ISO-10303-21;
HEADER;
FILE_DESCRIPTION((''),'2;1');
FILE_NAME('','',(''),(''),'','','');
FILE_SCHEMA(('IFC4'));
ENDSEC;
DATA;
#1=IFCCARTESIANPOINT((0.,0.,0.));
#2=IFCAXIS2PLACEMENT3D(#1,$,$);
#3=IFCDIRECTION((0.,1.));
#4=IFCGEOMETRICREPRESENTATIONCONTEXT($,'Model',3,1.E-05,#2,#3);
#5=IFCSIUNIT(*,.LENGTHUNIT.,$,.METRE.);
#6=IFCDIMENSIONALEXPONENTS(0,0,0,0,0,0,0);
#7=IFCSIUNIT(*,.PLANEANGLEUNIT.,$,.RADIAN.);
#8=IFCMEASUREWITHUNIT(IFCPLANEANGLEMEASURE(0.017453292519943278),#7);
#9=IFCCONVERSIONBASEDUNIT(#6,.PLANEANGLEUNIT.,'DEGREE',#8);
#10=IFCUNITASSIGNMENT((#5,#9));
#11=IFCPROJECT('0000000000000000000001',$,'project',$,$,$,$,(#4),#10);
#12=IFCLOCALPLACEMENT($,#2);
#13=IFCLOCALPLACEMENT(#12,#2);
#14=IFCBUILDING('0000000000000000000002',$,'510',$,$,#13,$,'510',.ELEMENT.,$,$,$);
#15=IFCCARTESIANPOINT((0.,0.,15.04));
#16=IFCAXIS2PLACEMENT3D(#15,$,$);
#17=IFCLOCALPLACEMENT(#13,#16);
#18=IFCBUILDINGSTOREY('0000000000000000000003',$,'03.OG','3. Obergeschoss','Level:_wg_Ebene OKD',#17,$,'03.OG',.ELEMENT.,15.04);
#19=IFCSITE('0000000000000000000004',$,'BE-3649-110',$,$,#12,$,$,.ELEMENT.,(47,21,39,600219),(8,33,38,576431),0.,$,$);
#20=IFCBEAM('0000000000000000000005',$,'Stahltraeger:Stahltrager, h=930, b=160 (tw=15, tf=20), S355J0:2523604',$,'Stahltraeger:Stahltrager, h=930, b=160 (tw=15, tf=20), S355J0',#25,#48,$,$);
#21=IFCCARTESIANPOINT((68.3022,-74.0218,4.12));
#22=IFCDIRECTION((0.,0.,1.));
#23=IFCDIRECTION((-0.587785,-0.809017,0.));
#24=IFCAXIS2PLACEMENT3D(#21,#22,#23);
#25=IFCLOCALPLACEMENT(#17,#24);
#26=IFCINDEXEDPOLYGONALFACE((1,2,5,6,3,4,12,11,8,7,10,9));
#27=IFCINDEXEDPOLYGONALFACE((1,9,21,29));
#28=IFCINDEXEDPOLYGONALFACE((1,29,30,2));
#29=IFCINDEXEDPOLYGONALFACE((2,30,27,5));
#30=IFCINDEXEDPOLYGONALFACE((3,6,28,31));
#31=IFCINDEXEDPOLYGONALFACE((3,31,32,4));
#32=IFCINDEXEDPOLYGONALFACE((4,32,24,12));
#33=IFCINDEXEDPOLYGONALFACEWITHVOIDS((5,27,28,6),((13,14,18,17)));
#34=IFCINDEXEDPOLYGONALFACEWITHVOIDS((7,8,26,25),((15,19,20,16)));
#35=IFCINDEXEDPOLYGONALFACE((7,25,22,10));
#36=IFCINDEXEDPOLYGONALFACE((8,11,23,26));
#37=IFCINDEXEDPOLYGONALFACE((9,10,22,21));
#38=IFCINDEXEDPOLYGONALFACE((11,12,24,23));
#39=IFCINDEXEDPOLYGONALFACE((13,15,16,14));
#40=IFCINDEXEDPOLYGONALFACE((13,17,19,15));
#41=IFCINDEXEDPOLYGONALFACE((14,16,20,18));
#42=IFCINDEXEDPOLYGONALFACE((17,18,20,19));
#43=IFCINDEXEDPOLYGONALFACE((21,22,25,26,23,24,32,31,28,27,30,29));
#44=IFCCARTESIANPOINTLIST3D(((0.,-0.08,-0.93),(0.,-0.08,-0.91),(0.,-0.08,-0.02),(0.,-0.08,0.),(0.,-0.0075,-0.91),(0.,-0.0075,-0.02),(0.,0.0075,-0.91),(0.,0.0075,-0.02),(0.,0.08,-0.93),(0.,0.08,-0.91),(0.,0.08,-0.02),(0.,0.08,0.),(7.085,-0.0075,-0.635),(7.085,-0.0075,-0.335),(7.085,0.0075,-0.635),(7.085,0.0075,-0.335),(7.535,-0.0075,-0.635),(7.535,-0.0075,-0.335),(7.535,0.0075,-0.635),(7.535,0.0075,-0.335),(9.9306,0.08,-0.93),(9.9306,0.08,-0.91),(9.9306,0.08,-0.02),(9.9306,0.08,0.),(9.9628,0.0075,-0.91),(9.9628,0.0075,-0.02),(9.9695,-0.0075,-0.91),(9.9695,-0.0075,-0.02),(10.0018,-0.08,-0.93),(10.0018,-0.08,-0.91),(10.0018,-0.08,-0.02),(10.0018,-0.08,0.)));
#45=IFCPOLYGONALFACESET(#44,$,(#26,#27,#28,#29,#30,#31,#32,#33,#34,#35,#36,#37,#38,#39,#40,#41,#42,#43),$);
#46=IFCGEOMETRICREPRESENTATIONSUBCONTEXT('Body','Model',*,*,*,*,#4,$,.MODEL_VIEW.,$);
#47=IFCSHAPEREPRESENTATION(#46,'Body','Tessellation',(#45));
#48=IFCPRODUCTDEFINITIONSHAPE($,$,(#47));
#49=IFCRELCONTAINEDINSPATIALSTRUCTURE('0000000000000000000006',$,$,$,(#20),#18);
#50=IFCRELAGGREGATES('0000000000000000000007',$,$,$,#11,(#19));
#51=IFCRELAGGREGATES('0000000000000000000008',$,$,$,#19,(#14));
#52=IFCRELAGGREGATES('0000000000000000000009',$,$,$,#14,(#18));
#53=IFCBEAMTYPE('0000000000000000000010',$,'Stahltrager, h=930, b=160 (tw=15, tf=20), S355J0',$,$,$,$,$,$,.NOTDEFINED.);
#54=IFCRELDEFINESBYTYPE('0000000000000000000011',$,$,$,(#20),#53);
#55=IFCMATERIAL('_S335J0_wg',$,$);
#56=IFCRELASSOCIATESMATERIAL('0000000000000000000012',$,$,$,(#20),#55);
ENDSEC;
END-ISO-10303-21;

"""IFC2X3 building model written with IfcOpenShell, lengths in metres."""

from ifc_helpers import new_model, entity, si_unit, converted_unit, direction, frame, frame_2d, origin, place, context, subcontext, project, spatial, rectangle, i_section, extrude, boolean, clip, halfspace, material, type_object, element, save


model = new_model("IFC2X3")

# Units and contexts
model_context = context("Model", 3, precision=1e-05, world=origin(), true_north=direction((0.0, 1.0)))
body_context = subcontext(model_context, "Body", "Model", "MODEL_VIEW")
ifc_project = project(units=[si_unit("LENGTHUNIT", "METRE"), converted_unit("PLANEANGLEUNIT", "DEGREE", entity("IfcPlaneAngleMeasure", 0.017453292519943278), si_unit("PLANEANGLEUNIT", "RADIAN"), dimensions=[0, 0, 0, 0, 0, 0, 0])], contexts=[model_context])

# Site, building, storey
site_placement = place(None, origin())
site = spatial("IfcSite", under=ifc_project, at=site_placement, Name="BE-3649-110", CompositionType="ELEMENT", RefLatitude=(47, 21, 39, 600219), RefLongitude=(8, 33, 38, 576431), RefElevation=0.0)
building_placement = place(site_placement, origin())
building = spatial("IfcBuilding", under=site, at=building_placement, Name="510", LongName="510", CompositionType="ELEMENT")
storey_placement = place(building_placement, frame((0.0, 0.0, 15.04)))
storey = spatial("IfcBuildingStorey", under=building, at=storey_placement, Name="03.OG", Description="3. Obergeschoss", ObjectType="Level:_wg_Ebene OKD", LongName="03.OG", CompositionType="ELEMENT", Elevation=15.04)

# Beam
ifc_material_1 = material(Name="_S335J0_wg")
beam_type_1 = type_object("IfcBeamType", Name="Stahltrager, h=930, b=160 (tw=15, tf=20), S355J0", PredefinedType="NOTDEFINED")
beam_1_placement = place(storey_placement, frame((68.3022, -74.0218, 4.12), z_axis=(0.0, 0.0, 1.0), x_axis=(-0.587785, -0.809017, 0.0)))
element("IfcBeam", 1, at=beam_1_placement, inside=storey, type_object=beam_type_1, material=ifc_material_1, Name="Stahltraeger:Stahltrager, h=930, b=160 (tw=15, tf=20), S355J0:2523604", ObjectType="Stahltraeger:Stahltrager, h=930, b=160 (tw=15, tf=20), S355J0", context=body_context, shape_type="SweptSolid", body=[
    boolean("DIFFERENCE", clip(extrude(i_section(OverallWidth=0.16, OverallDepth=0.93, WebThickness=0.015, FlangeThickness=0.02, at=frame_2d((0.0, 0.0), x_axis=(0.0, 1.0))), frame((0.0, 0.0, -0.465), z_axis=(1.0, 0.0, 0.0), x_axis=(0.0, 0.0, -1.0)), (0.0, 0.0, 1.0), 10.0018), halfspace(frame((9.7434, 0.5003, -19.38), z_axis=(0.913545, 0.406737, 0.0), x_axis=(0.406737, -0.913545, 0.0)), False)), extrude(rectangle(XDim=0.3, YDim=0.45, at=frame_2d((0.0, 0.0), x_axis=(0.0, 1.0))), frame((7.31, 0.0075, -0.485), z_axis=(0.0, -1.0, 0.0), x_axis=(-1.0, 0.0, 0.0)), (0.0, 0.0, 1.0), 0.015)),
])

save(model, "model.ifc")
